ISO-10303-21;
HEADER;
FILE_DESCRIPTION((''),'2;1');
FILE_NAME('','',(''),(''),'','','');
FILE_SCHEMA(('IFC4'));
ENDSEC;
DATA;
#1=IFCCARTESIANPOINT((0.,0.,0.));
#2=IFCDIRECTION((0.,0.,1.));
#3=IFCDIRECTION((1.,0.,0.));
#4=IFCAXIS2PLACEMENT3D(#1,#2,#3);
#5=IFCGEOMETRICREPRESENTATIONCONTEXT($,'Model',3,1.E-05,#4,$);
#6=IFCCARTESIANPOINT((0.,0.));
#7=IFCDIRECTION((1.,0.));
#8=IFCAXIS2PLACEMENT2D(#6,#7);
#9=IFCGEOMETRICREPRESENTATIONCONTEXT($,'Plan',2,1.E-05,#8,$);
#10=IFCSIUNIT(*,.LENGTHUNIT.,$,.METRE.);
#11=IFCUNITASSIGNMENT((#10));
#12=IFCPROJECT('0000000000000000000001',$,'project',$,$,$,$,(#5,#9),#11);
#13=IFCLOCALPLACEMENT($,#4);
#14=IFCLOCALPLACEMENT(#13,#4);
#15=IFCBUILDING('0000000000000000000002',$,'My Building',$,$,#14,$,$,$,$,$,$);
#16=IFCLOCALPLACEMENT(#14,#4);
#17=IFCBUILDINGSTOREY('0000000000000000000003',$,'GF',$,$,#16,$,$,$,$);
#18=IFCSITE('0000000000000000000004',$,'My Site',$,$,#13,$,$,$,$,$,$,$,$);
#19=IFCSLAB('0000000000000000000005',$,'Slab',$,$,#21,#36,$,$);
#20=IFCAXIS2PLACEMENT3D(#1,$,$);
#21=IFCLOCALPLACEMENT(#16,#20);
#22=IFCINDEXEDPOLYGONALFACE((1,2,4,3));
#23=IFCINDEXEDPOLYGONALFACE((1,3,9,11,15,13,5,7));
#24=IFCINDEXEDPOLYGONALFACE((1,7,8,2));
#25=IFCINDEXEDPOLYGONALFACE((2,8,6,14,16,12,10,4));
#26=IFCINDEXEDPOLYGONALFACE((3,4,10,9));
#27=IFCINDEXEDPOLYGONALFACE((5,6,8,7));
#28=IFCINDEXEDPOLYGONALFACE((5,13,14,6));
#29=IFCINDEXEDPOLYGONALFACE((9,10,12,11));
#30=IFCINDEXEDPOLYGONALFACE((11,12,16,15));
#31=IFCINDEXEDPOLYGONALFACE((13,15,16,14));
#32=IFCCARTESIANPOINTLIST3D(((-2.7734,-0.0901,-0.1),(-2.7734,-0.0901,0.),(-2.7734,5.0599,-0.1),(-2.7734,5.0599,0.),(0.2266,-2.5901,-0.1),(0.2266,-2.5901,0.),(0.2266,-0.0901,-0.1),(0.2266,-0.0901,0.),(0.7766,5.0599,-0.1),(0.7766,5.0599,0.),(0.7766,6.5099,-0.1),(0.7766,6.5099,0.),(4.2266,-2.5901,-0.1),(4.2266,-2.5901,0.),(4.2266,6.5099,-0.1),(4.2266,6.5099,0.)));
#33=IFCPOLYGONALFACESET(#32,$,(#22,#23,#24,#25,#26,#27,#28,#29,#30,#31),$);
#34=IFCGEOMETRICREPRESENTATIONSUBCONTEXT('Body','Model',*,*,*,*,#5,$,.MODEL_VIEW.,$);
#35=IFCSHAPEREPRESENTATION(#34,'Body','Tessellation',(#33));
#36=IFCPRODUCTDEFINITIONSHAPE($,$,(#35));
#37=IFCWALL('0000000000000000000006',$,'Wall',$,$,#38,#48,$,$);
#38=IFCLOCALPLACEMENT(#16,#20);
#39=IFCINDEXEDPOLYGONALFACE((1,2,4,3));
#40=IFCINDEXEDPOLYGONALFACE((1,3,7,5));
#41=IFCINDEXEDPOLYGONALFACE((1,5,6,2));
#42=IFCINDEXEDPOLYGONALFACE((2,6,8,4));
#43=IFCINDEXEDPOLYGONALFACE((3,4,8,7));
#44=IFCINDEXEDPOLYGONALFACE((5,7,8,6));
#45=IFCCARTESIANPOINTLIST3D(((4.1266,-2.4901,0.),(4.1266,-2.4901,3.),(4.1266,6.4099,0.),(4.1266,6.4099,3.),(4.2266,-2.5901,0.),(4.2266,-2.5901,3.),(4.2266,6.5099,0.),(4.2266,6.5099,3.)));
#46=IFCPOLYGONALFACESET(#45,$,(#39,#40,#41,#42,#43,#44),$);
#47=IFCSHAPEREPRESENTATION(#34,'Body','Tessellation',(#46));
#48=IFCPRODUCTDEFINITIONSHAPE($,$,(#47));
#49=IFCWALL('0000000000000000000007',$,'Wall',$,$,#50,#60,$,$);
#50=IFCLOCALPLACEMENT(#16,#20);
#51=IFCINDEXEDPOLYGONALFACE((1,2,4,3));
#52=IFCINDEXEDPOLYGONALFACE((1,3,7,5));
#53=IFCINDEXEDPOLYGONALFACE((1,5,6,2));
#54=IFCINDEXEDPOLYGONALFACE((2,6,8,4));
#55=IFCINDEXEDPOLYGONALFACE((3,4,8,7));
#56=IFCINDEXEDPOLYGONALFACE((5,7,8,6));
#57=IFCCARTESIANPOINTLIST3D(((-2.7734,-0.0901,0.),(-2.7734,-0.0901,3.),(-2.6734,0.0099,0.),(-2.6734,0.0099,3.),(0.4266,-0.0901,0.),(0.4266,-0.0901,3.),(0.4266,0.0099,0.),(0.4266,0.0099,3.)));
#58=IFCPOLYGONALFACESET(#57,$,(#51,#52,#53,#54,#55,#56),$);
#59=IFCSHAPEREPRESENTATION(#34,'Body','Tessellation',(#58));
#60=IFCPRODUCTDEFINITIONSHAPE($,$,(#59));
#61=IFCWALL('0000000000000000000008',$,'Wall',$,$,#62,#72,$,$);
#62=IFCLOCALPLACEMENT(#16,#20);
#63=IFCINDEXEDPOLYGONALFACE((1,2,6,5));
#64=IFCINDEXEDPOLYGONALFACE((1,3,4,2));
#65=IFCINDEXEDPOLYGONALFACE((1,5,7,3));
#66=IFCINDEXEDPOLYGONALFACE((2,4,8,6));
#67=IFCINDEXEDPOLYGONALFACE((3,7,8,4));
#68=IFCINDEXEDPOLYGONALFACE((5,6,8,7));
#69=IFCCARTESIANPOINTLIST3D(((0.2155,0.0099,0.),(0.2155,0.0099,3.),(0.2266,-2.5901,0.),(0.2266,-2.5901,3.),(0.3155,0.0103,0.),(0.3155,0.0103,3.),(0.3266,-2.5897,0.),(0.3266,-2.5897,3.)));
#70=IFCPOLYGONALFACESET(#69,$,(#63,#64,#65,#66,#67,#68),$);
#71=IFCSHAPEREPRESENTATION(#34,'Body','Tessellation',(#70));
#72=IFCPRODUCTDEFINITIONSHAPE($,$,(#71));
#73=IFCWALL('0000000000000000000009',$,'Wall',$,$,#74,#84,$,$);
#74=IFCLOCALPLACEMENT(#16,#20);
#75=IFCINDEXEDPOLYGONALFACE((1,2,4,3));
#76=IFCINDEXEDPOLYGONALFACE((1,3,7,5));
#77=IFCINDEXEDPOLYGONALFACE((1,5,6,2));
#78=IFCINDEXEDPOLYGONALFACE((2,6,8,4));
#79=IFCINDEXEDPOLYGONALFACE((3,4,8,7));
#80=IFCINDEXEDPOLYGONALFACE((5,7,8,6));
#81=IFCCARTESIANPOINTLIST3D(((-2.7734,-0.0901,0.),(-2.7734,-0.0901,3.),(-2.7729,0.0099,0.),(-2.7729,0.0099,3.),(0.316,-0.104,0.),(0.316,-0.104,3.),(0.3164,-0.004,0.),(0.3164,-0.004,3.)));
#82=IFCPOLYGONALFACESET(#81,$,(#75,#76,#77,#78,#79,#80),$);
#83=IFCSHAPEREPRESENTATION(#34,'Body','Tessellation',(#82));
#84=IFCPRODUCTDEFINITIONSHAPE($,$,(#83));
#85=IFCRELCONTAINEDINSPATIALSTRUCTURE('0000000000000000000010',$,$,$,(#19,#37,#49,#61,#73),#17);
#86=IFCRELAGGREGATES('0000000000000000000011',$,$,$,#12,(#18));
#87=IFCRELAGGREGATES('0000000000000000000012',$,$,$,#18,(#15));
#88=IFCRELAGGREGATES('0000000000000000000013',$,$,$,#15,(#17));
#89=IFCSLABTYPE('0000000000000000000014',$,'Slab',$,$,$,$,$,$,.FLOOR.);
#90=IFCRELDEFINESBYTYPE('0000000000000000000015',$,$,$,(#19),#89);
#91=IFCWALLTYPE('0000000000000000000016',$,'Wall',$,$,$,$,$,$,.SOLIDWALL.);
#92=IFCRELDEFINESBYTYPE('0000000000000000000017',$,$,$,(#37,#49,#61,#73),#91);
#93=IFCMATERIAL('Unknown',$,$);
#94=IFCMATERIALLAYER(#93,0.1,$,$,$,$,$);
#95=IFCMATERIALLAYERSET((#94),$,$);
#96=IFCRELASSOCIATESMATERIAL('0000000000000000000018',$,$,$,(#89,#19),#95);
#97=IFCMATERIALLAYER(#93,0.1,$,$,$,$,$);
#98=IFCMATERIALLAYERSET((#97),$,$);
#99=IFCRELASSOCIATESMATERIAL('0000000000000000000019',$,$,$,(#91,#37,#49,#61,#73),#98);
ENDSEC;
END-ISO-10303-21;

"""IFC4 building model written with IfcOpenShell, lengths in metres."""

from ifc_helpers import new_model, si_unit, frame, origin_with_axes, origin_2d_with_axis, place, context, subcontext, project, spatial, line, indexed_curve, outline, extrude, material, layer, layer_set, layer_usage, type_object, element, save


model = new_model("IFC4")

# Units and contexts
model_context = context("Model", 3, precision=1e-05, world=origin_with_axes())
plan_context = context("Plan", 2, precision=1e-05, world=origin_2d_with_axis())
body_context_1 = subcontext(model_context, "Body", "Model", "MODEL_VIEW")
ifc_project = project(units=[si_unit("LENGTHUNIT", "METRE")], contexts=[model_context, plan_context])

# Site, building, storey
site_placement = place(None, origin_with_axes())
site = spatial("IfcSite", under=ifc_project, at=site_placement, Name="My Site")
building_placement = place(site_placement, origin_with_axes())
building = spatial("IfcBuilding", under=site, at=building_placement, Name="My Building")
storey_placement = place(building_placement, origin_with_axes())
storey = spatial("IfcBuildingStorey", under=building, at=storey_placement, Name="GF")

# Slab
ifc_material = material(Name="Unknown")
ifc_layer_1 = layer(ifc_material, 0.1)
ifc_layer_set_1 = layer_set([ifc_layer_1])
ifc_layer_usage_1 = layer_usage(ifc_layer_set_1, "AXIS3", "POSITIVE", -0.1)
slab_type = type_object("IfcSlabType", Name="Slab", PredefinedType="FLOOR", material=ifc_layer_set_1)
slab_placement = place(storey_placement, frame((4.2266, -2.5901, 0.0), z_axis=(0.0, 0.0, 1.0), x_axis=(1.0, 0.0, 0.0)))
element("IfcSlab", 1, at=slab_placement, inside=storey, type_object=slab_type, material=ifc_layer_usage_1, Name="Slab", context=body_context_1, shape_type="SweptSolid", body=[
    extrude(outline(indexed_curve([(0.0, 0.0), (0.0, 9.1), (-3.45, 9.1), (-3.45, 7.65), (-7.0, 7.65), (-7.0, 2.5), (-4.0, 2.5), (-4.0, 0.0), (0.0, 0.0)])), frame((0.0, 0.0, -0.1), z_axis=(0.0, 0.0, 1.0), x_axis=(1.0, 0.0, 0.0)), (0.0, 0.0, 1.0), 0.1),
])

# Shared definitions
ifc_layer_2 = layer(ifc_material, 0.1)
ifc_layer_set_2 = layer_set([ifc_layer_2])
wall_type = type_object("IfcWallType", Name="Wall", PredefinedType="SOLIDWALL", material=ifc_layer_set_2)

# Walls
ifc_layer_usage_2 = layer_usage(ifc_layer_set_2, "AXIS2", "POSITIVE", 0.0)
wall_1_placement = place(storey_placement, frame((4.2266, -2.5901, 0.0), z_axis=(0.0, 0.0, 1.0), x_axis=(0.0, 1.0, 0.0)))
element("IfcWall", 2, at=wall_1_placement, inside=storey, type_object=wall_type, material=ifc_layer_usage_2, Name="Wall", context=body_context_1, shape_type="SweptSolid", body=[
    extrude(outline(indexed_curve([(0.0, 0.0), (0.1, 0.1), (9.0, 0.1), (9.1, 0.0)], segments=[line(1, 2, 3, 4, 1)])), origin_with_axes(), (0.0, 0.0, 1.0), 3.0),
])
ifc_layer_usage_3 = layer_usage(ifc_layer_set_2, "AXIS2", "POSITIVE", 0.0)
wall_2_placement = place(storey_placement, frame((-2.7734, -0.0901, 0.0), z_axis=(0.0, 0.0, 1.0), x_axis=(1.0, 0.0, 0.0)))
element("IfcWall", 3, at=wall_2_placement, inside=storey, type_object=wall_type, material=ifc_layer_usage_3, Name="Wall", context=body_context_1, shape_type="SweptSolid", body=[
    extrude(outline(indexed_curve([(0.0, 0.0), (0.1, 0.1), (3.2, 0.1), (3.2, 0.0)], segments=[line(1, 2, 3, 4, 1)])), origin_with_axes(), (0.0, 0.0, 1.0), 3.0),
])
ifc_layer_usage_4 = layer_usage(ifc_layer_set_2, "AXIS2", "POSITIVE", 0.0)
wall_3_placement = place(storey_placement, frame((0.2155, 0.0099, 0.0), z_axis=(0.0, 0.0, 1.0), x_axis=(0.004272, -0.999991, 0.0)))
element("IfcWall", 4, at=wall_3_placement, inside=storey, type_object=wall_type, material=ifc_layer_usage_4, Name="Wall", context=body_context_1, shape_type="SweptSolid", body=[
    extrude(outline(indexed_curve([(0.0, 0.0), (0.0, 0.1), (2.6, 0.1), (2.6, 0.0)], segments=[line(1, 2, 3, 4, 1)])), origin_with_axes(), (0.0, 0.0, 1.0), 3.0),
])
ifc_layer_usage_5 = layer_usage(ifc_layer_set_2, "AXIS2", "POSITIVE", 0.0)
wall_4_placement = place(storey_placement, frame((-2.7734, -0.0901, 0.0), z_axis=(0.0, 0.0, 1.0), x_axis=(0.99999, -0.004496, 0.0)))
element("IfcWall", 5, at=wall_4_placement, inside=storey, type_object=wall_type, material=ifc_layer_usage_5, Name="Wall", context=body_context_1, shape_type="SweptSolid", body=[
    extrude(outline(indexed_curve([(0.0, 0.0), (0.0, 0.1), (3.0894, 0.1), (3.0894, 0.0)], segments=[line(1, 2, 3, 4, 1)])), origin_with_axes(), (0.0, 0.0, 1.0), 3.0),
])

save(model, "model.ifc")
